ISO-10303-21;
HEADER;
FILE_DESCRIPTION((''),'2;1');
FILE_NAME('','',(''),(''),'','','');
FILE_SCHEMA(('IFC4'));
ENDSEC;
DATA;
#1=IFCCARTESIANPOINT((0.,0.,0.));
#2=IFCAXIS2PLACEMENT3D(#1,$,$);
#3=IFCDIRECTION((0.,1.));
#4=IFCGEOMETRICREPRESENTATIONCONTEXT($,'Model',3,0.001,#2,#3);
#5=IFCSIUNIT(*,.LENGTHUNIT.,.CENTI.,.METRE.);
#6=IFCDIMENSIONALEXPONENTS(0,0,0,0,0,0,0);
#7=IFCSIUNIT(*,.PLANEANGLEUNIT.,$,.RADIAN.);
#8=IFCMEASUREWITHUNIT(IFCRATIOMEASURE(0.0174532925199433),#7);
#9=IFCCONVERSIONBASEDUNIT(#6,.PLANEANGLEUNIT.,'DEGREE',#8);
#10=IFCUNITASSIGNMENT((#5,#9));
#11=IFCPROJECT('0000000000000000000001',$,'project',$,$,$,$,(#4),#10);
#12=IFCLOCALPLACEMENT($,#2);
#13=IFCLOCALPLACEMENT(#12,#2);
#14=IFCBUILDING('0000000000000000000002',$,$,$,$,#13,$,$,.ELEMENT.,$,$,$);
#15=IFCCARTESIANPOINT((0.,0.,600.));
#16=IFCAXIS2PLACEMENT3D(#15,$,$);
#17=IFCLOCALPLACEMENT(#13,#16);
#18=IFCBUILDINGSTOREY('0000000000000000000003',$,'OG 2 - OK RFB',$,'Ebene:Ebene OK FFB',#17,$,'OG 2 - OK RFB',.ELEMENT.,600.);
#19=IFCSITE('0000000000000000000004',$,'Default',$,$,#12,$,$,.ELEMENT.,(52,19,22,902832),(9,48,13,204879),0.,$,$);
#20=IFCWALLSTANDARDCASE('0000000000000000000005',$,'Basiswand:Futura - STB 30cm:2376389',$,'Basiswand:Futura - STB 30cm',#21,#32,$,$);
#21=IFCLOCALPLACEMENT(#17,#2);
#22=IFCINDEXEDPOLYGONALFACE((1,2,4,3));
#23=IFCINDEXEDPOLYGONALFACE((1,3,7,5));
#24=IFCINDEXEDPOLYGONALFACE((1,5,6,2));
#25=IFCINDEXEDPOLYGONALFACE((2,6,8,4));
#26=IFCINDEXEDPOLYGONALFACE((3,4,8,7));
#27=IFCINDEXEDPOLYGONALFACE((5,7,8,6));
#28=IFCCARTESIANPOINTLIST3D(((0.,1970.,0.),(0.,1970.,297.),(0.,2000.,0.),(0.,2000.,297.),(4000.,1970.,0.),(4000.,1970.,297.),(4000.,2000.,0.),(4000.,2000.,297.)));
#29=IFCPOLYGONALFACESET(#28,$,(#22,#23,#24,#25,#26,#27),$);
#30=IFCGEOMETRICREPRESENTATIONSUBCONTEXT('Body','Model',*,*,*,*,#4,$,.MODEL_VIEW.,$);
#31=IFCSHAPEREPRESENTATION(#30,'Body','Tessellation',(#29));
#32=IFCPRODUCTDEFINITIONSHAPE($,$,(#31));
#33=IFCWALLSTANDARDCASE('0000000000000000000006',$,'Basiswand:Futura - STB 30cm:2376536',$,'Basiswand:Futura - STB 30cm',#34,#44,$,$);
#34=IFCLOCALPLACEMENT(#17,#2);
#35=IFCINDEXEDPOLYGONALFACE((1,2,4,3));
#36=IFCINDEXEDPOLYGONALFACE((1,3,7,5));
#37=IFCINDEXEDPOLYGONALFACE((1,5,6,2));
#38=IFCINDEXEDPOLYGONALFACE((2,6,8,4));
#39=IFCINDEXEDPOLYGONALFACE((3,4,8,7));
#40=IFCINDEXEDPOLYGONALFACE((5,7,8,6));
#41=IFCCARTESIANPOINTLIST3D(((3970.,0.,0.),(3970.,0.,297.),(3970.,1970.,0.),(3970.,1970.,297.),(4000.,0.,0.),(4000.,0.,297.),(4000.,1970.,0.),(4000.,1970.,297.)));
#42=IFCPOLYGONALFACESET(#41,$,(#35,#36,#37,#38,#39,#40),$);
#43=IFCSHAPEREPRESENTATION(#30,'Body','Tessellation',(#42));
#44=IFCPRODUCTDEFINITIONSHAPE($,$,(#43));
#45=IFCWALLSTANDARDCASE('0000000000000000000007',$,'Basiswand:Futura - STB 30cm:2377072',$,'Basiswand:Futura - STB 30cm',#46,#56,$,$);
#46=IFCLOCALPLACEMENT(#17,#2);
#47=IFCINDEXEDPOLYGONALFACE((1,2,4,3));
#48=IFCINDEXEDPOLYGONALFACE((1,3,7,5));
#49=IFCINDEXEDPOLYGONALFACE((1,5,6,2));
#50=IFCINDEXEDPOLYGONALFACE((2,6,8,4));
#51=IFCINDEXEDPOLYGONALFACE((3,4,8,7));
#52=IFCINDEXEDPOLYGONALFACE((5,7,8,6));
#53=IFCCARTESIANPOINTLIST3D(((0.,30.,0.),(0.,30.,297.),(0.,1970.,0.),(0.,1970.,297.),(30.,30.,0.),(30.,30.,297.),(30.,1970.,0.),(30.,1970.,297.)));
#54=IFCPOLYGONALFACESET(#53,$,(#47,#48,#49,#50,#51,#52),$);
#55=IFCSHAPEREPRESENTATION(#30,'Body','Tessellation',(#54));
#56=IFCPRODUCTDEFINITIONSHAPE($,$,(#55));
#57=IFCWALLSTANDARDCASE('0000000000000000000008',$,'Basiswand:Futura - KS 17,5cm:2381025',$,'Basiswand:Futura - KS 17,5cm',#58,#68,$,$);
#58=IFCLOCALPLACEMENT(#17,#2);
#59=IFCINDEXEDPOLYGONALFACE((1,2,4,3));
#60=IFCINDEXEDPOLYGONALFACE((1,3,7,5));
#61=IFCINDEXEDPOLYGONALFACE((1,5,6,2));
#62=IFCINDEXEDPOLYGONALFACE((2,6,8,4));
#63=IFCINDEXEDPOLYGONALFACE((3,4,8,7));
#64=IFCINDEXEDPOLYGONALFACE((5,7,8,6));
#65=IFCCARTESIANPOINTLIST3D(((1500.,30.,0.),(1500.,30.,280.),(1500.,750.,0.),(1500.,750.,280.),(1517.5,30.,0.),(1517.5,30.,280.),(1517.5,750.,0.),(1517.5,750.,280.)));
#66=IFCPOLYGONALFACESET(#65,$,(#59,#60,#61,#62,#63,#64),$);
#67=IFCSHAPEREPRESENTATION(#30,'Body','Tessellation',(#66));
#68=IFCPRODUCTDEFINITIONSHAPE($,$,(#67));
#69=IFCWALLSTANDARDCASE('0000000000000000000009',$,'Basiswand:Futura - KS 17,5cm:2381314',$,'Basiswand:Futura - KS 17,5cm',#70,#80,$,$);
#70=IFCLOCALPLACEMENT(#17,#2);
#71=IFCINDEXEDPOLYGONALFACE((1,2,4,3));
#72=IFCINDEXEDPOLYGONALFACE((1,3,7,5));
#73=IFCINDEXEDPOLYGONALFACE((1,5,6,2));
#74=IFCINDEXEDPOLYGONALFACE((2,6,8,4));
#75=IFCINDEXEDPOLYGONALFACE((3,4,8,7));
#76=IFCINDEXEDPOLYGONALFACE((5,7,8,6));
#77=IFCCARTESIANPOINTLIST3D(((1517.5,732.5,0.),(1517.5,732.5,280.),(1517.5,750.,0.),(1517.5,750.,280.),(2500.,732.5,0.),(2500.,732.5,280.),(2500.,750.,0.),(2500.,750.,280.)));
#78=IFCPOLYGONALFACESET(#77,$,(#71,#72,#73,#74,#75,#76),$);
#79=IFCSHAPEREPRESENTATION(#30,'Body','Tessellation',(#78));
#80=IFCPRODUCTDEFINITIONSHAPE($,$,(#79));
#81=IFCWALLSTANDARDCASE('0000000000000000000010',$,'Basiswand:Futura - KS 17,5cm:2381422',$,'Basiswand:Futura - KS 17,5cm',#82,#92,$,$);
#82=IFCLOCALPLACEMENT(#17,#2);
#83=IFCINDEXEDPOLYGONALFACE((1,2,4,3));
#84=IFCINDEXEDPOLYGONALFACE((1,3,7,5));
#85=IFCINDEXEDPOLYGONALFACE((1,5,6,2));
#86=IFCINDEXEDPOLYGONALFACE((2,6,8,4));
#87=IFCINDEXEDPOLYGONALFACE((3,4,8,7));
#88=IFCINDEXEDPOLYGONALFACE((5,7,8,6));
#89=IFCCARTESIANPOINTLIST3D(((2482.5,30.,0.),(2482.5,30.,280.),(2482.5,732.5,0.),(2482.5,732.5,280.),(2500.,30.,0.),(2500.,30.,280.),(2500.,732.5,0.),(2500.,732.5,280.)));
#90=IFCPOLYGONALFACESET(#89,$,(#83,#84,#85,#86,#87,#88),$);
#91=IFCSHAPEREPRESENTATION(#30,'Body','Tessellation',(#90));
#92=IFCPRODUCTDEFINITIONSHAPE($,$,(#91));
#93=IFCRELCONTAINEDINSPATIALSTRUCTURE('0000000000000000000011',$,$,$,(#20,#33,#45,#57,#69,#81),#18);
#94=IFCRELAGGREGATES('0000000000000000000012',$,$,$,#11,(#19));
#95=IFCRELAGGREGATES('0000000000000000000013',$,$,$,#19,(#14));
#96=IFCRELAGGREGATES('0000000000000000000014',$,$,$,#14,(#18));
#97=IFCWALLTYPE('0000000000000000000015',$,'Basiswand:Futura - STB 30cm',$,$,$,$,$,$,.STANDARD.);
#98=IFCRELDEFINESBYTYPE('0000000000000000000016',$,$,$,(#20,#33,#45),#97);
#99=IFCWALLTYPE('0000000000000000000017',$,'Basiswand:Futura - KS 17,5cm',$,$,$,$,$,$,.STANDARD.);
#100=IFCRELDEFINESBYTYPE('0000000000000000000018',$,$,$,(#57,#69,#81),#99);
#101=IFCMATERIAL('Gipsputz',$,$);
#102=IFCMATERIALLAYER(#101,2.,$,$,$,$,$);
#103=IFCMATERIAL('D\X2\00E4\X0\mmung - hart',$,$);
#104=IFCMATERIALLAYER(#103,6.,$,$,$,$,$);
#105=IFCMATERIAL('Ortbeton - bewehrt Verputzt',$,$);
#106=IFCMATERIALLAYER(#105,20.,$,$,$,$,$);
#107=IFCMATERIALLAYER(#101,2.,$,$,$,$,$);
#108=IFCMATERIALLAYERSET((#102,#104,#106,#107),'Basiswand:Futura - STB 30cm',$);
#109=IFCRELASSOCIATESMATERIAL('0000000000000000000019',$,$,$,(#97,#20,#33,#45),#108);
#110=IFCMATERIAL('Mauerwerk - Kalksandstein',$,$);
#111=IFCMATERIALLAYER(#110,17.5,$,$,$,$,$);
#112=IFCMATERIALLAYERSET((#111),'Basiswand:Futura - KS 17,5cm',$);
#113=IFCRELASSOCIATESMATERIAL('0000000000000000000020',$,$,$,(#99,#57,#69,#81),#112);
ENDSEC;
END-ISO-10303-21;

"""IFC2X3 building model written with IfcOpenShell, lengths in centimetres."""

from ifc_helpers import new_model, entity, si_unit, converted_unit, direction, frame, frame_2d, origin, place, context, subcontext, project, spatial, polyline, rectangle, extrude, clip, bounded_halfspace, material, layer, layer_set, layer_usage, type_object, element, save


model = new_model("IFC2X3")

# Units and contexts
model_context = context("Model", 3, precision=0.001, world=origin(), true_north=direction((0.0, 1.0)))
body_context = subcontext(model_context, "Body", "Model", "MODEL_VIEW")
ifc_project = project(units=[si_unit("LENGTHUNIT", "METRE", prefix="CENTI"), converted_unit("PLANEANGLEUNIT", "DEGREE", entity("IfcRatioMeasure", 0.0174532925199433), si_unit("PLANEANGLEUNIT", "RADIAN"), dimensions=[0, 0, 0, 0, 0, 0, 0])], contexts=[model_context])

# Site, building, storey
site_placement = place(None, frame((0.0, 0.0, 0.0)))
site = spatial("IfcSite", under=ifc_project, at=site_placement, Name="Default", CompositionType="ELEMENT", RefLatitude=(52, 19, 22, 902832), RefLongitude=(9, 48, 13, 204879), RefElevation=0.0)
building_placement = place(site_placement, origin())
building = spatial("IfcBuilding", under=site, at=building_placement, CompositionType="ELEMENT")
storey_placement = place(building_placement, frame((0.0, 0.0, 600.0)))
storey = spatial("IfcBuildingStorey", under=building, at=storey_placement, Name="OG 2 - OK RFB", ObjectType="Ebene:Ebene OK FFB", LongName="OG 2 - OK RFB", CompositionType="ELEMENT", Elevation=600.0)

# Walls
ifc_material_1 = material(Name="Gipsputz")
ifc_layer_1 = layer(ifc_material_1, 2.0)
ifc_material_2 = material(Name="Dämmung - hart")
ifc_layer_2 = layer(ifc_material_2, 6.0)
ifc_material_3 = material(Name="Ortbeton - bewehrt Verputzt")
ifc_layer_3 = layer(ifc_material_3, 20.0)
ifc_layer_4 = layer(ifc_material_1, 2.0)
ifc_layer_set_1 = layer_set([ifc_layer_1, ifc_layer_2, ifc_layer_3, ifc_layer_4], Name="Basiswand:Futura - STB 30cm")
ifc_layer_usage_1 = layer_usage(ifc_layer_set_1, "AXIS2", "NEGATIVE", 15.0)
wall_type_1 = type_object("IfcWallType", Name="Basiswand:Futura - STB 30cm", PredefinedType="STANDARD", material=ifc_layer_set_1)
wall_1_placement = place(storey_placement, frame((0.0, 1985.0, 0.0)))
element("IfcWallStandardCase", 1, at=wall_1_placement, inside=storey, type_object=wall_type_1, material=ifc_layer_usage_1, Name="Basiswand:Futura - STB 30cm:2376389", ObjectType="Basiswand:Futura - STB 30cm", context=body_context, shape_type="Clipping", body=[
    clip(extrude(rectangle(XDim=4000.0, YDim=30.0, at=frame_2d((2000.0, 0.0), x_axis=(-1.0, 0.0))), origin(), (0.0, 0.0, 1.0), 297.0), bounded_halfspace(frame((0.0, -15.0, 297.0), z_axis=(0.0, 0.0, 1.0), x_axis=(-1.0, 0.0, 0.0)), False, frame((0.0, -15.0, 297.0)), polyline([(0.0, 0.0), (30.0, 0.0), (3970.0, 0.0), (4000.0, 0.0), (4000.0, 30.0), (0.0, 30.0), (0.0, 0.0)]))),
])
ifc_layer_usage_2 = layer_usage(ifc_layer_set_1, "AXIS2", "NEGATIVE", 15.0)
wall_2_placement = place(storey_placement, frame((3985.0, 1970.0, 0.0), z_axis=(0.0, 0.0, 1.0), x_axis=(0.0, -1.0, 0.0)))
element("IfcWallStandardCase", 2, at=wall_2_placement, inside=storey, type_object=wall_type_1, material=ifc_layer_usage_2, Name="Basiswand:Futura - STB 30cm:2376536", ObjectType="Basiswand:Futura - STB 30cm", context=body_context, shape_type="Clipping", body=[
    clip(extrude(rectangle(XDim=1970.0, YDim=30.0, at=frame_2d((985.0, 0.0), x_axis=(-1.0, 0.0))), origin(), (0.0, 0.0, 1.0), 297.0), bounded_halfspace(frame((0.0, -15.0, 297.0), z_axis=(0.0, 0.0, 1.0), x_axis=(0.0, -1.0, 0.0)), False, frame((0.0, -15.0, 297.0)), polyline([(0.0, 0.0), (1940.0, 0.0), (1970.0, 0.0), (1970.0, 30.0), (0.0, 30.0), (0.0, 0.0)]))),
])
ifc_layer_usage_3 = layer_usage(ifc_layer_set_1, "AXIS2", "NEGATIVE", 15.0)
wall_3_placement = place(storey_placement, frame((15.0, 30.0, 0.0), z_axis=(0.0, 0.0, 1.0), x_axis=(-0.000002, 1.0, 0.0)))
element("IfcWallStandardCase", 3, at=wall_3_placement, inside=storey, type_object=wall_type_1, material=ifc_layer_usage_3, Name="Basiswand:Futura - STB 30cm:2377072", ObjectType="Basiswand:Futura - STB 30cm", context=body_context, shape_type="Clipping", body=[
    clip(extrude(rectangle(XDim=1940.0, YDim=30.0, at=frame_2d((970.0, 0.0), x_axis=(-1.0, 0.0))), origin(), (0.0, 0.0, 1.0), 297.0), bounded_halfspace(frame((0.0, -15.0, 297.0), z_axis=(0.0, 0.0, 1.0), x_axis=(0.000002, 1.0, 0.0)), False, frame((0.0, -15.0, 297.0)), polyline([(0.0, 0.0), (1940.0, 0.0), (1940.0, 30.0), (0.0, 30.0), (0.0, 0.0)]))),
])
ifc_material_4 = material(Name="Mauerwerk - Kalksandstein")
ifc_layer_5 = layer(ifc_material_4, 17.5)
ifc_layer_set_2 = layer_set([ifc_layer_5], Name="Basiswand:Futura - KS 17,5cm")
ifc_layer_usage_4 = layer_usage(ifc_layer_set_2, "AXIS2", "NEGATIVE", 8.75)
wall_type_2 = type_object("IfcWallType", Name="Basiswand:Futura - KS 17,5cm", PredefinedType="STANDARD", material=ifc_layer_set_2)
wall_4_placement = place(storey_placement, frame((1508.75, 30.0, 0.0), z_axis=(0.0, 0.0, 1.0), x_axis=(0.0, 1.0, 0.0)))
element("IfcWallStandardCase", 4, at=wall_4_placement, inside=storey, type_object=wall_type_2, material=ifc_layer_usage_4, Name="Basiswand:Futura - KS 17,5cm:2381025", ObjectType="Basiswand:Futura - KS 17,5cm", context=body_context, shape_type="SweptSolid", body=[
    extrude(rectangle(XDim=720.0, YDim=17.5, at=frame_2d((360.0, 0.0), x_axis=(-1.0, 0.0))), origin(), (0.0, 0.0, 1.0), 280.0),
])
ifc_layer_usage_5 = layer_usage(ifc_layer_set_2, "AXIS2", "NEGATIVE", 8.75)
wall_5_placement = place(storey_placement, frame((1517.5, 741.25, 0.0)))
element("IfcWallStandardCase", 5, at=wall_5_placement, inside=storey, type_object=wall_type_2, material=ifc_layer_usage_5, Name="Basiswand:Futura - KS 17,5cm:2381314", ObjectType="Basiswand:Futura - KS 17,5cm", context=body_context, shape_type="SweptSolid", body=[
    extrude(rectangle(XDim=982.5, YDim=17.5, at=frame_2d((491.25, 0.0), x_axis=(-1.0, 0.0))), origin(), (0.0, 0.0, 1.0), 280.0),
])
ifc_layer_usage_6 = layer_usage(ifc_layer_set_2, "AXIS2", "NEGATIVE", 8.75)
wall_6_placement = place(storey_placement, frame((2491.25, 732.5, 0.0), z_axis=(0.0, 0.0, 1.0), x_axis=(0.0, -1.0, 0.0)))
element("IfcWallStandardCase", 6, at=wall_6_placement, inside=storey, type_object=wall_type_2, material=ifc_layer_usage_6, Name="Basiswand:Futura - KS 17,5cm:2381422", ObjectType="Basiswand:Futura - KS 17,5cm", context=body_context, shape_type="SweptSolid", body=[
    extrude(rectangle(XDim=702.5, YDim=17.5, at=frame_2d((351.25, 0.0), x_axis=(-1.0, 0.0))), origin(), (0.0, 0.0, 1.0), 280.0),
])

save(model, "model.ifc")
